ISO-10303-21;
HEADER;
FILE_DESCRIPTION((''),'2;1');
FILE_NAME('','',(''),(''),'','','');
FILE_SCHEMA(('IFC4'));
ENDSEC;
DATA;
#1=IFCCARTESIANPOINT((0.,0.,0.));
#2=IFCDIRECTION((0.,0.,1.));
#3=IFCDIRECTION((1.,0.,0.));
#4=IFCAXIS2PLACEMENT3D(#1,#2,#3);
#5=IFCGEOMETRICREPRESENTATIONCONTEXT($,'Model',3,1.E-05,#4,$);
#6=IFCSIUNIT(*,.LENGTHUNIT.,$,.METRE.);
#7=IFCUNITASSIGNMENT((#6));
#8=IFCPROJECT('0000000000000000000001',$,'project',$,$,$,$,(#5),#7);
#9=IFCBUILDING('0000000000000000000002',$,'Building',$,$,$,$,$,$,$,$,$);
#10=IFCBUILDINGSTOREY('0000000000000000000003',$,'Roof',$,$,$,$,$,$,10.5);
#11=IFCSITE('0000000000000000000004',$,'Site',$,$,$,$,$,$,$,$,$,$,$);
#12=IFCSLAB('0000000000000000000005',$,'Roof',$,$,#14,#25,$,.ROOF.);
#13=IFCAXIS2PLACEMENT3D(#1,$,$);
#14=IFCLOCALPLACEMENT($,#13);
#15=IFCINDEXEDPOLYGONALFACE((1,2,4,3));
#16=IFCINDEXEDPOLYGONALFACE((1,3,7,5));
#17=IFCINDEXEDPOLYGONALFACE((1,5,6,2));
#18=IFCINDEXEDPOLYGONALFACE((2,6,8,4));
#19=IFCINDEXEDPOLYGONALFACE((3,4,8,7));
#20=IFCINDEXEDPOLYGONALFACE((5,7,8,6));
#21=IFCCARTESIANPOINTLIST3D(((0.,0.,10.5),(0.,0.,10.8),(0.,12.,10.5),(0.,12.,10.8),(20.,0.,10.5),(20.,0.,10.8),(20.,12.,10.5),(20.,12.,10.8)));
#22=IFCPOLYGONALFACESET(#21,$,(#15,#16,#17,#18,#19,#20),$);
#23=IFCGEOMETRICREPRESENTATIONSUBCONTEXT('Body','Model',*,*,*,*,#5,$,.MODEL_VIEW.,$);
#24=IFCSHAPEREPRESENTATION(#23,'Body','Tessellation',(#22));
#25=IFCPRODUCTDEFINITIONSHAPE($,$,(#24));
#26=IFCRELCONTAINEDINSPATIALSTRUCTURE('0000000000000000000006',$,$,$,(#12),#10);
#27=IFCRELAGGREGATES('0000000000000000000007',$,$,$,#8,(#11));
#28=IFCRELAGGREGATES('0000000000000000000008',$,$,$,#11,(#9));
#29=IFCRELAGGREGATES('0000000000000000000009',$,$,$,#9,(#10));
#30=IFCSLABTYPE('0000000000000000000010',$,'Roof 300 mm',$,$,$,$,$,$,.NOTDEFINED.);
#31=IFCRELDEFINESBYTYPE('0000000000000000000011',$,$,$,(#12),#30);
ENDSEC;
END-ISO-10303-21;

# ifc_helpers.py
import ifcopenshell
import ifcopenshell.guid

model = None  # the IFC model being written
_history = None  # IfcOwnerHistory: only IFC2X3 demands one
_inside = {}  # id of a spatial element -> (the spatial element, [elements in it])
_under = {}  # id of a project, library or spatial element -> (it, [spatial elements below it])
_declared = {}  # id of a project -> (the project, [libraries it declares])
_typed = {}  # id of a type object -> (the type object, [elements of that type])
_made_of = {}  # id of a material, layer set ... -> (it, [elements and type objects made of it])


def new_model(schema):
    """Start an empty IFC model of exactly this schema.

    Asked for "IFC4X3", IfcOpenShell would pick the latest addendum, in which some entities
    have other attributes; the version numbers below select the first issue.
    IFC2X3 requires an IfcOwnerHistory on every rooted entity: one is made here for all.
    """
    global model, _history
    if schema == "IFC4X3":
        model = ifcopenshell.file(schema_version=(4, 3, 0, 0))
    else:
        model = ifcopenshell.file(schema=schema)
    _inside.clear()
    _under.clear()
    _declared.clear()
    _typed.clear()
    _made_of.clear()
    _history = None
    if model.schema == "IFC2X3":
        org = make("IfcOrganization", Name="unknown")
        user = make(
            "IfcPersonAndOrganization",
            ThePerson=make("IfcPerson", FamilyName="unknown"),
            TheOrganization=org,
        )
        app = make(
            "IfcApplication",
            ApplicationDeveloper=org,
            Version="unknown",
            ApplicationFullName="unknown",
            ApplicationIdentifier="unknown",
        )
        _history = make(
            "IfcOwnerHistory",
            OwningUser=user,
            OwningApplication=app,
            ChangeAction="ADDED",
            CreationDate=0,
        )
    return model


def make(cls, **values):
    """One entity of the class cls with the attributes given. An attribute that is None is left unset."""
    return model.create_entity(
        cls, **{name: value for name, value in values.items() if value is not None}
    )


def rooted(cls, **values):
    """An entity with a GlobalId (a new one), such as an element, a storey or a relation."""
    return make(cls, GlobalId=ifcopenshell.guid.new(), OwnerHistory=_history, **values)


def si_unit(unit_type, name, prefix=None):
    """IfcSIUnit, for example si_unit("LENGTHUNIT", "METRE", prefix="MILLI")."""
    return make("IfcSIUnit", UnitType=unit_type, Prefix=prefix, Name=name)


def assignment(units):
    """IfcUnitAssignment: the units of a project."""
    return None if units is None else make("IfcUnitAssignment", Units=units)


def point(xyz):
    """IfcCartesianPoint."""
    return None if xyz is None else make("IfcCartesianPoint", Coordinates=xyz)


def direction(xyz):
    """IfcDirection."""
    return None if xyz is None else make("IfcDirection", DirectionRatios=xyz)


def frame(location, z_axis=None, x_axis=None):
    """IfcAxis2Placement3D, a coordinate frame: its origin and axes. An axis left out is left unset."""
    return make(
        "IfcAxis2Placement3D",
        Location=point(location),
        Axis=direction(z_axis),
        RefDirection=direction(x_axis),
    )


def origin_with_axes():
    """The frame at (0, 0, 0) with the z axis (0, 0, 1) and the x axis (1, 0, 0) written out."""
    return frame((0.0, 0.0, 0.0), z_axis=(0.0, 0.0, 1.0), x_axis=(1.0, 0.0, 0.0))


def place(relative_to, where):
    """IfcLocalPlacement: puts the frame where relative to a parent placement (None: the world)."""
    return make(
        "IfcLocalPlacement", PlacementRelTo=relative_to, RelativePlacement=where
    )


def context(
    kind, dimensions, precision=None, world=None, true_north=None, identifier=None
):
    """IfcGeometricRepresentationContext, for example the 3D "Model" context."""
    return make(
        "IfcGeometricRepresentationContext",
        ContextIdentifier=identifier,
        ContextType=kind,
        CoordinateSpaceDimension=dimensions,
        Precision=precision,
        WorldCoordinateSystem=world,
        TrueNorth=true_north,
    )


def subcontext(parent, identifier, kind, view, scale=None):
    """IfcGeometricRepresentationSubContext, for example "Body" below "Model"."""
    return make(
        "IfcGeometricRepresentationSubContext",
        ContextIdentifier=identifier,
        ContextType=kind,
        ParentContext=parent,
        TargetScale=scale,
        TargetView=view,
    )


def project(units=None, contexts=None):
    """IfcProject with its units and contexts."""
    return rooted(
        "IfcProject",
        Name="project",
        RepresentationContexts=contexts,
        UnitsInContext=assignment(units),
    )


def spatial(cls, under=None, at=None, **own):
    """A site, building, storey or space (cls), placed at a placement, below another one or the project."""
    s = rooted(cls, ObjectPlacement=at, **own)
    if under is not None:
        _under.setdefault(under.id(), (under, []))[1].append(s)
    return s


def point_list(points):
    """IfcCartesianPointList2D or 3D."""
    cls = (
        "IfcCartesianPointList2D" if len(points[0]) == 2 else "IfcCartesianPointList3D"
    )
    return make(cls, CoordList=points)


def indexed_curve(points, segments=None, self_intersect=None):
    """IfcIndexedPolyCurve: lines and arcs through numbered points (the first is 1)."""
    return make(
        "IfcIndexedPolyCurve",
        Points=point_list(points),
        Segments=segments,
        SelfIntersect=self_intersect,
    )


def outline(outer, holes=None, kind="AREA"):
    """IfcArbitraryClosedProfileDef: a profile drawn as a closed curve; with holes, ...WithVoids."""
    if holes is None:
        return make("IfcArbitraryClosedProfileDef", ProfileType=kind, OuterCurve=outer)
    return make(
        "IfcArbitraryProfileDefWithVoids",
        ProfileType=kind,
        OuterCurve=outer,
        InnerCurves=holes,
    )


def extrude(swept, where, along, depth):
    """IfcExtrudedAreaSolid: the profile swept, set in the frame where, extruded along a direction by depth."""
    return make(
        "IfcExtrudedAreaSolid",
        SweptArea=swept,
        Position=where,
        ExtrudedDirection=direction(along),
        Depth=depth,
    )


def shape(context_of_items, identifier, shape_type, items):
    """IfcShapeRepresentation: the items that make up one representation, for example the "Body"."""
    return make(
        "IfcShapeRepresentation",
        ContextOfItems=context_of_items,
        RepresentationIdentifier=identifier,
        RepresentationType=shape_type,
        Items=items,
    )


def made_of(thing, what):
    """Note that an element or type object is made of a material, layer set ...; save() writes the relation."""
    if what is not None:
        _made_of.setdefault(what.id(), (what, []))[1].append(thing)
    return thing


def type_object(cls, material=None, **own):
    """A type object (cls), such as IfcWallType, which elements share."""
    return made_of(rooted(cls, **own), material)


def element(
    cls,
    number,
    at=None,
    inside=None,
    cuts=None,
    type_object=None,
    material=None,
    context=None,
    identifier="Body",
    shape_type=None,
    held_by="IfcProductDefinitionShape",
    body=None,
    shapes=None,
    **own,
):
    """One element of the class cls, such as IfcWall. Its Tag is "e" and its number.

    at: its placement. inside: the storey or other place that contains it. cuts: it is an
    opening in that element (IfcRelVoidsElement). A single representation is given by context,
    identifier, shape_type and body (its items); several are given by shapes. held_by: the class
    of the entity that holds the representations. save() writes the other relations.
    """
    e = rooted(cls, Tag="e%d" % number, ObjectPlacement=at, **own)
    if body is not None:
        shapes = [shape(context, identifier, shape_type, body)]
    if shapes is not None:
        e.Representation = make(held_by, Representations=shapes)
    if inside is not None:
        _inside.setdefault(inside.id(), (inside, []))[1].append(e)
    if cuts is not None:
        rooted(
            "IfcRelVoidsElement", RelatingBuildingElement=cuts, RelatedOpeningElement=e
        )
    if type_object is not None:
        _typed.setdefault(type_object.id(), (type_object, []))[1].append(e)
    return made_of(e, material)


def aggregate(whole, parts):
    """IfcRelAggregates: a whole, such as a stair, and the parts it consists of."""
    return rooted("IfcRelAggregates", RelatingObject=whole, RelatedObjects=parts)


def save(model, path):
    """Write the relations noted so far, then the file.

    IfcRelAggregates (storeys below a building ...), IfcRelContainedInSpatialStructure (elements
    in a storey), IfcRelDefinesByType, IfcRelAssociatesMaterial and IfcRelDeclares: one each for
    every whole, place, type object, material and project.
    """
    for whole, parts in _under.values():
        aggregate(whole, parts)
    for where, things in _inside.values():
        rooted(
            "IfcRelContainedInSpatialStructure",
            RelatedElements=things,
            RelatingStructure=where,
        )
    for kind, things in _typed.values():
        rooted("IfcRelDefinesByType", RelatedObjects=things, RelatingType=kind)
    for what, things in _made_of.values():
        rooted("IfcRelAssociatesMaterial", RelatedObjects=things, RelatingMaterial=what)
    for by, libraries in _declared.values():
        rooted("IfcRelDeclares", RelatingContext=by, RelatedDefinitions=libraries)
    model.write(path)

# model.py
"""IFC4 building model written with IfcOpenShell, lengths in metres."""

from ifc_helpers import new_model, si_unit, frame, origin_with_axes, place, context, subcontext, project, spatial, indexed_curve, outline, extrude, type_object, element, save


model = new_model("IFC4")

# Units and contexts
model_context = context("Model", 3, precision=1e-05, world=origin_with_axes())
body_context = subcontext(model_context, "Body", "Model", "MODEL_VIEW")
ifc_project = project(units=[si_unit("LENGTHUNIT", "METRE")], contexts=[model_context])

# Site, building, storey
site = spatial("IfcSite", under=ifc_project, Name="Site")
building = spatial("IfcBuilding", under=site, Name="Building")
storey = spatial("IfcBuildingStorey", under=building, Name="Roof", Elevation=10.5)

# Slab
slab_type = type_object("IfcSlabType", Name="Roof 300 mm", PredefinedType="NOTDEFINED")
slab_placement = place(None, frame((0.0, 0.0, 10.5), z_axis=(0.0, 0.0, 1.0), x_axis=(1.0, 0.0, 0.0)))
element("IfcSlab", 1, at=slab_placement, inside=storey, type_object=slab_type, Name="Roof", PredefinedType="ROOF", context=body_context, shape_type="SweptSolid", body=[
    extrude(outline(indexed_curve([(0.0, 0.0), (20.0, 0.0), (20.0, 12.0), (0.0, 12.0)])), None, (0.0, 0.0, 1.0), 0.3),
])

save(model, "model.ifc")
